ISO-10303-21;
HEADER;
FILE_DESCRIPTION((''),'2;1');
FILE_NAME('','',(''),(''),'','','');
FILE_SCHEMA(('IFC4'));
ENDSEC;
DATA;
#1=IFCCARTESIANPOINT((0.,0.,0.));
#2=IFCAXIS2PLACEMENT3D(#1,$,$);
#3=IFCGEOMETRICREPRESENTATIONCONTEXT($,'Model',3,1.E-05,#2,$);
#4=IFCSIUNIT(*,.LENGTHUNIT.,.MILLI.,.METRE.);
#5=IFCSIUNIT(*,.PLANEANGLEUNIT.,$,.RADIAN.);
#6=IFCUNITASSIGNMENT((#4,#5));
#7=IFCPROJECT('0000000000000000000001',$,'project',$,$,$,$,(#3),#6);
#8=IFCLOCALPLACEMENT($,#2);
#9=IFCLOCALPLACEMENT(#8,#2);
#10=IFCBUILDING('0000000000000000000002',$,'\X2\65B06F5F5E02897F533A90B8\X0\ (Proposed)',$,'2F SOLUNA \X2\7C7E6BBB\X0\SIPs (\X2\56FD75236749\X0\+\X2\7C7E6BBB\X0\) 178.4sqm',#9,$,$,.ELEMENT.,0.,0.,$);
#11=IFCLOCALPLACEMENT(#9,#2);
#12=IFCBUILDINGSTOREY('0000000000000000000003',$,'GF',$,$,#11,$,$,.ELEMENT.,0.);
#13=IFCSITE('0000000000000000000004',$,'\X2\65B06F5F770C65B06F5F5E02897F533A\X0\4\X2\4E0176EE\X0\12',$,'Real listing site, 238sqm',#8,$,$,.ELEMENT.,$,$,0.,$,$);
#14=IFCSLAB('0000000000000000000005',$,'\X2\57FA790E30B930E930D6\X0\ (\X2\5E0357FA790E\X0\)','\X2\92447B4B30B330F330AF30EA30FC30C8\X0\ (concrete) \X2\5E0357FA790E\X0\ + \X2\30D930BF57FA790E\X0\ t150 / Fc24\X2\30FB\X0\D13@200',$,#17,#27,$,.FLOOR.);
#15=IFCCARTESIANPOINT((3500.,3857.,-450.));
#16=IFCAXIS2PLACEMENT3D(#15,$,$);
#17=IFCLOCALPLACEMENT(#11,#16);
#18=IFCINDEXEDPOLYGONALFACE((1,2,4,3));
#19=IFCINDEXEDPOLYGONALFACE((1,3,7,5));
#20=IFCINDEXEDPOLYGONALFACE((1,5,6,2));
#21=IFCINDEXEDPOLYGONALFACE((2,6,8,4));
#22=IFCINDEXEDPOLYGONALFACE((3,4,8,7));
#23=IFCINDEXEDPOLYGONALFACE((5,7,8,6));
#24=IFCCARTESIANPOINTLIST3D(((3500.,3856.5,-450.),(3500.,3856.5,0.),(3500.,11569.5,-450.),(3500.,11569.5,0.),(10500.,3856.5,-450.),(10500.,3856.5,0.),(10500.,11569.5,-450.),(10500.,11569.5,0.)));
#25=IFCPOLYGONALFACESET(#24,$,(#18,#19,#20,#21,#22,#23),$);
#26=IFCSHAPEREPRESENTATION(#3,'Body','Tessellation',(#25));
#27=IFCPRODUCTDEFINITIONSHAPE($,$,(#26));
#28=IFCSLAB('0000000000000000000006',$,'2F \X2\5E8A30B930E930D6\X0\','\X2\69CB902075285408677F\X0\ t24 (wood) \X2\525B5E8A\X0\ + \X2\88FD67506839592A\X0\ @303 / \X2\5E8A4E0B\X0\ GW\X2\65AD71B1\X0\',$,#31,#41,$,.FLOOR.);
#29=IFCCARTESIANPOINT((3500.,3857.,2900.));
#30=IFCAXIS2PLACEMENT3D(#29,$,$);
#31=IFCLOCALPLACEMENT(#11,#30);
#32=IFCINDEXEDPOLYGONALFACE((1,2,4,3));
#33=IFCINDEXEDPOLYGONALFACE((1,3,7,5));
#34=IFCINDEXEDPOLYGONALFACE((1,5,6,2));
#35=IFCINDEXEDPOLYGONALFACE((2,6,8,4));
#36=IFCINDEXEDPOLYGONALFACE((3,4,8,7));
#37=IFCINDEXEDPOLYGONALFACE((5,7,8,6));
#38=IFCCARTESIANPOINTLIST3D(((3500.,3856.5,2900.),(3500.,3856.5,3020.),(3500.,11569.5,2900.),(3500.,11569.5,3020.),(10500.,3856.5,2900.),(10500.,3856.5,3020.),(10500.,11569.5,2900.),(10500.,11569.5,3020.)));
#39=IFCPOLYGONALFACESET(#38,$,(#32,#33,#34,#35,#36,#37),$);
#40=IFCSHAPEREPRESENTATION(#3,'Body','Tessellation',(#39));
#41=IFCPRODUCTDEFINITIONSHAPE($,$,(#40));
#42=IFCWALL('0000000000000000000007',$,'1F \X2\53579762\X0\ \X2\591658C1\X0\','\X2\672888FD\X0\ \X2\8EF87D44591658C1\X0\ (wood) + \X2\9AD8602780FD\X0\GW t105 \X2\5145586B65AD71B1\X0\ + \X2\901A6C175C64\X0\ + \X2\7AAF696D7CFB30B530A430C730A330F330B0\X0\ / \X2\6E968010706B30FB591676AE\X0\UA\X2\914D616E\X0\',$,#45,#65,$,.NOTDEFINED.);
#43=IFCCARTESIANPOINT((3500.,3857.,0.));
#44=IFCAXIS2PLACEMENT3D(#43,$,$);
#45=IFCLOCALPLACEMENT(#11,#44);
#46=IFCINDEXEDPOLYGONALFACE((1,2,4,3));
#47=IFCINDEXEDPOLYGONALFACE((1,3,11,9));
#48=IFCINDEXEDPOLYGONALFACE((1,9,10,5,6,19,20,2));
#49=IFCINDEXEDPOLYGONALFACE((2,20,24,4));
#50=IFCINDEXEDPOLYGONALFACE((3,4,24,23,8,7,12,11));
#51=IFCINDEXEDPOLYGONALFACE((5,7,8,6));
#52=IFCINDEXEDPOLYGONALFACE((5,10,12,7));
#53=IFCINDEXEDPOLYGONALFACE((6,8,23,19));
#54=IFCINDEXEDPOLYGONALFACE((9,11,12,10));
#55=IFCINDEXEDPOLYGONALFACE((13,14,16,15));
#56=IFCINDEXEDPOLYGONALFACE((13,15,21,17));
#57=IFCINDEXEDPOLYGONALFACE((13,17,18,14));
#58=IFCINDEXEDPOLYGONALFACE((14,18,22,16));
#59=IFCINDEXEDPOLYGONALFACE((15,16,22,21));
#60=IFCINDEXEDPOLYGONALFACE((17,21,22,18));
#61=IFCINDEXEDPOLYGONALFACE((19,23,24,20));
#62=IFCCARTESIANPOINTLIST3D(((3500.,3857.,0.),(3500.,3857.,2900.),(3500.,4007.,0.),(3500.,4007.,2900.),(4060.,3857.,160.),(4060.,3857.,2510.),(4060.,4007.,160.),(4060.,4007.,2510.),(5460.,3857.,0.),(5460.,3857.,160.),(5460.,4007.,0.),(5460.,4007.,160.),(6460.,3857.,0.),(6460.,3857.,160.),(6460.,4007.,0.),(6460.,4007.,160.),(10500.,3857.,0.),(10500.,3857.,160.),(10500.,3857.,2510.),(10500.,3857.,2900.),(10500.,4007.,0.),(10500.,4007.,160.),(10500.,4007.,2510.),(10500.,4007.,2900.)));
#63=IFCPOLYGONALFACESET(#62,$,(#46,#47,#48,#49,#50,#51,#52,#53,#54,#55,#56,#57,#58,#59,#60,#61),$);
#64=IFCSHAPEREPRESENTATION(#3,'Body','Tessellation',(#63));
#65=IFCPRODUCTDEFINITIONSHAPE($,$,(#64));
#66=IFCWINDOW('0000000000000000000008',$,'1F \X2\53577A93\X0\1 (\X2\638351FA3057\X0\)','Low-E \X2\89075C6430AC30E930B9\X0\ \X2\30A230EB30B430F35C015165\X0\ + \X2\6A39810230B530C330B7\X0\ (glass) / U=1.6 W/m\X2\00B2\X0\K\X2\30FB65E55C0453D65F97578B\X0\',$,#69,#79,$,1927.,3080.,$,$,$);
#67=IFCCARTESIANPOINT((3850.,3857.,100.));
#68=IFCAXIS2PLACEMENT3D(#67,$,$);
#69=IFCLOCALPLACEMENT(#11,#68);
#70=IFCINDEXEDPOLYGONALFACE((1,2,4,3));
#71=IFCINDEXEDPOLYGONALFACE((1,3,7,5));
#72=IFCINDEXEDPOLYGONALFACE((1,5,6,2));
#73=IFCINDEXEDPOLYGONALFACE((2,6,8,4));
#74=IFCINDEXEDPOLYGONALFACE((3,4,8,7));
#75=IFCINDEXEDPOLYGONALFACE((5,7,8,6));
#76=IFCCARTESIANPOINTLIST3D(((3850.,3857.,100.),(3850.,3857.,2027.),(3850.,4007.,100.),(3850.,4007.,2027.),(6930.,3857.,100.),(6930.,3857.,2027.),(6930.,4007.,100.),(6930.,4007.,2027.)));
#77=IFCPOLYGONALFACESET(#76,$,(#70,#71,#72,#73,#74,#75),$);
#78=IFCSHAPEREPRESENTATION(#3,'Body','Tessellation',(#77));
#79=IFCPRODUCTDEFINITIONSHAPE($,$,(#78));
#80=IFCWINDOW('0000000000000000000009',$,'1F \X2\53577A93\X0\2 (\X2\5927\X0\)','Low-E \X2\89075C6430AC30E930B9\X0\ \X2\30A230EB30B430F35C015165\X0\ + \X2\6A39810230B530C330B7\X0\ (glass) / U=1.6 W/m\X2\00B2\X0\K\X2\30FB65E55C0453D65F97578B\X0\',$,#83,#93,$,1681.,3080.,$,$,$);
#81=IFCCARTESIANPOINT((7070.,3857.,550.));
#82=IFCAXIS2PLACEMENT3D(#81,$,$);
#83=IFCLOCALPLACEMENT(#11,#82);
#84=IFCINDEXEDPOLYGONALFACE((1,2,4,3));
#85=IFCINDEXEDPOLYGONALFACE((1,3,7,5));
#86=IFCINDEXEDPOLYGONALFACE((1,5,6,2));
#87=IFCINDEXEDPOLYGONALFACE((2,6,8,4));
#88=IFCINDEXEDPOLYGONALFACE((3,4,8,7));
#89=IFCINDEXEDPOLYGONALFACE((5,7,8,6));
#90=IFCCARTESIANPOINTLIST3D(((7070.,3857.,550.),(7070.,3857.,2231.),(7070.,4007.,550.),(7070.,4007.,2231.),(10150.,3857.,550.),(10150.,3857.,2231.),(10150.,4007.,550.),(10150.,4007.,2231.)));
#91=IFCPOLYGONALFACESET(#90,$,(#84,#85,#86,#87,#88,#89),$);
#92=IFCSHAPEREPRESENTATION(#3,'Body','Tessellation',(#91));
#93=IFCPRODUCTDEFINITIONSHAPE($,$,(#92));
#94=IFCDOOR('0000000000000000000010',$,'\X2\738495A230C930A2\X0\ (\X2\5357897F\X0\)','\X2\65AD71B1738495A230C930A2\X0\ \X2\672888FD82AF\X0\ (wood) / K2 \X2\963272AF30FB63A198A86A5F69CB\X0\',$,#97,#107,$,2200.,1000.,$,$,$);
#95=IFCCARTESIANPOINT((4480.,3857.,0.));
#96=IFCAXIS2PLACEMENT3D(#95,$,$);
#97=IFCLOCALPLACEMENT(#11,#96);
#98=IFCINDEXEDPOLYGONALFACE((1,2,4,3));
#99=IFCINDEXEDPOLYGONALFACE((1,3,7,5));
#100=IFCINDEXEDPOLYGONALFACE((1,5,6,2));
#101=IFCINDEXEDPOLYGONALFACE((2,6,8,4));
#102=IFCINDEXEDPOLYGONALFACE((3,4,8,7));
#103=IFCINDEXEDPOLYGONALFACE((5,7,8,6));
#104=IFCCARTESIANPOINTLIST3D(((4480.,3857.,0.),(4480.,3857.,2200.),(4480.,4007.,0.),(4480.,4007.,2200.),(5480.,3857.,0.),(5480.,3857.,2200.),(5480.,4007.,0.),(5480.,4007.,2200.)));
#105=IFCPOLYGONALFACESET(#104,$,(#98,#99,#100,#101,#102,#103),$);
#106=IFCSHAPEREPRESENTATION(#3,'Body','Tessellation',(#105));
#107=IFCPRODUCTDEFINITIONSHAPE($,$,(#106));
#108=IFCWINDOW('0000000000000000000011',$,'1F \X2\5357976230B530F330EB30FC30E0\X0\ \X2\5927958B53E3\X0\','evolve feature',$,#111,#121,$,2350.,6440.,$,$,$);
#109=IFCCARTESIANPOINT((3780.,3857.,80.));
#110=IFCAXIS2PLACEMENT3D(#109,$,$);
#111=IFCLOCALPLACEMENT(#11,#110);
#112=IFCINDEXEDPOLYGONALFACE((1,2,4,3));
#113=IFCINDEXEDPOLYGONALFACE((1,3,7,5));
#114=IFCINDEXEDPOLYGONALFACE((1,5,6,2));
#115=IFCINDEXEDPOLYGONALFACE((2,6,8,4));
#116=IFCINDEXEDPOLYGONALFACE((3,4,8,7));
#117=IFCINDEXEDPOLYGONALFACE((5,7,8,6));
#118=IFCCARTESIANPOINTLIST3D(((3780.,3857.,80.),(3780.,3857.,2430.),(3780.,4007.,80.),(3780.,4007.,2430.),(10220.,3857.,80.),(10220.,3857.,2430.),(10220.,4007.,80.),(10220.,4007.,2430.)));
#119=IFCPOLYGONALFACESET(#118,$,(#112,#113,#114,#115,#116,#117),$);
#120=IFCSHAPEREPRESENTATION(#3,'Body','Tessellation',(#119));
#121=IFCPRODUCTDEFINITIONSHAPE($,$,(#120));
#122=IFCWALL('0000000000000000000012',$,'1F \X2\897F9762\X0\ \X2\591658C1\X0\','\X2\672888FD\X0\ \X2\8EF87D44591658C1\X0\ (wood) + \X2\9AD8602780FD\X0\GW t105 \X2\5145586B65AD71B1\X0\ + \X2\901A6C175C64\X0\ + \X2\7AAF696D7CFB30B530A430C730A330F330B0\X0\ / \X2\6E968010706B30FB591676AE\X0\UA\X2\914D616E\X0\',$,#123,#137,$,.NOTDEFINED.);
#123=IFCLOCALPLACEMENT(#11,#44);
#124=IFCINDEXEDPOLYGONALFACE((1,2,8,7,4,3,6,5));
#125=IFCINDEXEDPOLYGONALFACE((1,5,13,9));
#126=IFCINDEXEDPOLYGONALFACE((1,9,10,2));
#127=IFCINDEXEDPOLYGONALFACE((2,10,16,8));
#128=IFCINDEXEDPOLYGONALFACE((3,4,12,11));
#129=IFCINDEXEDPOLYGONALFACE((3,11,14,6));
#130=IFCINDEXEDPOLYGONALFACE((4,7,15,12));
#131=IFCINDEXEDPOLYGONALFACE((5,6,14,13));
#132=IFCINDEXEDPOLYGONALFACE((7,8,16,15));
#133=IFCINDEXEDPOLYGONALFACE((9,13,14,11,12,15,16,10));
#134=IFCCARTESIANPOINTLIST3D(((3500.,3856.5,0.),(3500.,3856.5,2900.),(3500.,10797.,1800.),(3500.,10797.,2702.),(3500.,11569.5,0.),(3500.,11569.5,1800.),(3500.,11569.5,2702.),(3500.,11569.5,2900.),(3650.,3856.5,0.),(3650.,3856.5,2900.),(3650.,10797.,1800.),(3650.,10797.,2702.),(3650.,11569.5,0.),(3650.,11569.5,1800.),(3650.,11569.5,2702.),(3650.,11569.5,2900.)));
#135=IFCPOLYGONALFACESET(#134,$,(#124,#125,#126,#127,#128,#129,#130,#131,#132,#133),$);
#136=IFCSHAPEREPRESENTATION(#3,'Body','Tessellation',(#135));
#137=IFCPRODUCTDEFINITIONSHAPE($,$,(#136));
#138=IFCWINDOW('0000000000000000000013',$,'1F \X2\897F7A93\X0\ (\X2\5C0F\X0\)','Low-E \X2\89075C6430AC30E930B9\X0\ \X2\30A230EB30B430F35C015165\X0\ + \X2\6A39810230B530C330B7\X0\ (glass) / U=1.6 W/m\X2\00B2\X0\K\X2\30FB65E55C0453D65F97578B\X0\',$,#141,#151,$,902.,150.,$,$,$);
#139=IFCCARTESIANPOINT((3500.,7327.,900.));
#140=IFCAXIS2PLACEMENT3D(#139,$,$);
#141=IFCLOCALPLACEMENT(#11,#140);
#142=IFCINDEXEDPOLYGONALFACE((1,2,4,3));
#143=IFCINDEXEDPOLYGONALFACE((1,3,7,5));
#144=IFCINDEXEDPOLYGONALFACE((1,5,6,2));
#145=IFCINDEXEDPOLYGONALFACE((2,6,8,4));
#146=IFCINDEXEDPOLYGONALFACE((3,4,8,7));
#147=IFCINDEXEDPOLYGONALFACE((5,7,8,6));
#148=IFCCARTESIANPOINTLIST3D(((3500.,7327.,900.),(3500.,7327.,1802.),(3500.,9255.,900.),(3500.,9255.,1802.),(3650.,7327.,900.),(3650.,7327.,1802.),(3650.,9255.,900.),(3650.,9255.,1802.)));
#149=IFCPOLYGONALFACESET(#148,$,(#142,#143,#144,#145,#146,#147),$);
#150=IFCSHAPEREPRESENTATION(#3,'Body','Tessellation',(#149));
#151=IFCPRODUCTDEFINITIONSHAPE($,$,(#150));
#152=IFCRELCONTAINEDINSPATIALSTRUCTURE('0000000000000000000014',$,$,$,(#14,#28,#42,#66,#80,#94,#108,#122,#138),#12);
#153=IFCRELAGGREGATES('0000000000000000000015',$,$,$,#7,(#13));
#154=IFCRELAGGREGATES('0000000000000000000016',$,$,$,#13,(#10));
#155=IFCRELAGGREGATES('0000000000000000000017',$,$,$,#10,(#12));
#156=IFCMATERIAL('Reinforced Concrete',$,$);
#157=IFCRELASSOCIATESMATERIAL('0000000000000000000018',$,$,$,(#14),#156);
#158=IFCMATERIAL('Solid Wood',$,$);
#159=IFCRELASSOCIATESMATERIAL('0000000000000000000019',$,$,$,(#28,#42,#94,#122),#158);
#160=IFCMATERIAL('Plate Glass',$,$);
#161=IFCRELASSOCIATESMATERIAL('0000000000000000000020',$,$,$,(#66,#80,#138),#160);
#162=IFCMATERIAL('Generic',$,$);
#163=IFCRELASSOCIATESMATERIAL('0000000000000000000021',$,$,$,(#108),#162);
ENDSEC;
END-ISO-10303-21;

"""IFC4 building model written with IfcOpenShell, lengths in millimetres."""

from ifc_helpers import new_model, si_unit, frame, frame_2d, origin, place, context, project, spatial, rectangle, extrude, material, element, fill, save


model = new_model("IFC4")

# Units and contexts
model_context = context("Model", 3, precision=1e-05, world=origin())
ifc_project = project(units=[si_unit("LENGTHUNIT", "METRE", prefix="MILLI"), si_unit("PLANEANGLEUNIT", "RADIAN")], contexts=[model_context])

# Site, building, storey
site_placement = place(None, origin())
site = spatial("IfcSite", under=ifc_project, at=site_placement, Name="新潟県新潟市西区4丁目12", ObjectType="Real listing site, 238sqm", CompositionType="ELEMENT", RefElevation=0.0)
building_placement = place(site_placement, origin())
building = spatial("IfcBuilding", under=site, at=building_placement, Name="新潟市西区邸 (Proposed)", ObjectType="2F SOLUNA 籾殻SIPs (国産杉+籾殻) 178.4sqm", CompositionType="ELEMENT", ElevationOfRefHeight=0.0, ElevationOfTerrain=0.0)
storey_placement = place(building_placement, origin())
storey = spatial("IfcBuildingStorey", under=building, at=storey_placement, Name="GF", CompositionType="ELEMENT", Elevation=0.0)

# Slabs
ifc_material_1 = material(Name="Reinforced Concrete")
slab_1_placement = place(storey_placement, frame((3500.0, 3857.0, -450.0)))
element("IfcSlab", 1, at=slab_1_placement, inside=storey, material=ifc_material_1, Name="基礎スラブ (布基礎)", Description="鉄筋コンクリート (concrete) 布基礎 + ベタ基礎 t150 / Fc24・D13@200", PredefinedType="FLOOR", context=model_context, shape_type="SweptSolid", body=[
    extrude(rectangle(XDim=7000.0, YDim=7713.0, at=frame_2d((3500.0, 3856.0))), frame((3500.0, 3857.0, -450.0)), (0.0, 0.0, 1.0), 450.0),
])
ifc_material_2 = material(Name="Solid Wood")
slab_2_placement = place(storey_placement, frame((3500.0, 3857.0, 2900.0)))
element("IfcSlab", 2, at=slab_2_placement, inside=storey, material=ifc_material_2, Name="2F 床スラブ", Description="構造用合板 t24 (wood) 剛床 + 製材根太 @303 / 床下 GW断熱", PredefinedType="FLOOR", context=model_context, shape_type="SweptSolid", body=[
    extrude(rectangle(XDim=7000.0, YDim=7713.0, at=frame_2d((3500.0, 3856.0))), frame((3500.0, 3857.0, 2900.0)), (0.0, 0.0, 1.0), 120.0),
])
ifc_material_3 = material(Name="Generic")

# Wall, openings, windows, door
wall_1_placement = place(storey_placement, frame((3500.0, 3857.0, 0.0)))
wall_1 = element("IfcWall", 3, at=wall_1_placement, inside=storey, material=ifc_material_2, Name="1F 南面 外壁", Description="木製 軸組外壁 (wood) + 高性能GW t105 充填断熱 + 通気層 + 窯業系サイディング / 準耐火・外皮UA配慮", PredefinedType="NOTDEFINED", context=model_context, shape_type="SweptSolid", body=[
    extrude(rectangle(XDim=7000.0, YDim=150.0, at=frame_2d((3500.0, 75.0))), frame((3500.0, 3857.0, 0.0)), (0.0, 0.0, 1.0), 2900.0),
])
opening_1_placement = place(storey_placement, frame((3850.0, 3857.0, 100.0)))
opening_1 = element("IfcOpeningElement", 4, at=opening_1_placement, cuts=wall_1, PredefinedType="NOTDEFINED", context=model_context, shape_type="SweptSolid", body=[
    extrude(rectangle(XDim=3080.0, YDim=150.0, at=frame_2d((1540.0, 75.0))), frame((3850.0, 3857.0, 100.0)), (0.0, 0.0, 1.0), 1927.0),
])
opening_2_placement = place(storey_placement, frame((7070.0, 3857.0, 550.0)))
opening_2 = element("IfcOpeningElement", 5, at=opening_2_placement, cuts=wall_1, PredefinedType="NOTDEFINED", context=model_context, shape_type="SweptSolid", body=[
    extrude(rectangle(XDim=3080.0, YDim=150.0, at=frame_2d((1540.0, 75.0))), frame((7070.0, 3857.0, 550.0)), (0.0, 0.0, 1.0), 1681.0),
])
opening_3_placement = place(storey_placement, frame((4480.0, 3857.0, 0.0)))
opening_3 = element("IfcOpeningElement", 6, at=opening_3_placement, cuts=wall_1, PredefinedType="NOTDEFINED", context=model_context, shape_type="SweptSolid", body=[
    extrude(rectangle(XDim=1000.0, YDim=150.0, at=frame_2d((500.0, 75.0))), frame((4480.0, 3857.0, 0.0)), (0.0, 0.0, 1.0), 2200.0),
])
opening_4_placement = place(storey_placement, frame((3780.0, 3857.0, 80.0)))
opening_4 = element("IfcOpeningElement", 7, at=opening_4_placement, cuts=wall_1, PredefinedType="NOTDEFINED", context=model_context, shape_type="SweptSolid", body=[
    extrude(rectangle(XDim=6440.0, YDim=150.0, at=frame_2d((3220.0, 75.0))), frame((3780.0, 3857.0, 80.0)), (0.0, 0.0, 1.0), 2350.0),
])
ifc_material_4 = material(Name="Plate Glass")
window_1_placement = place(storey_placement, frame((3850.0, 3857.0, 100.0)))
window_1 = element("IfcWindow", 8, at=window_1_placement, inside=storey, material=ifc_material_4, Name="1F 南窓1 (掃出し)", Description="Low-E 複層ガラス アルゴン封入 + 樹脂サッシ (glass) / U=1.6 W/m²K・日射取得型", OverallHeight=1927.0, OverallWidth=3080.0, context=model_context, shape_type="SweptSolid", body=[
    extrude(rectangle(XDim=3080.0, YDim=150.0, at=frame_2d((1540.0, 75.0))), frame((3850.0, 3857.0, 100.0)), (0.0, 0.0, 1.0), 1927.0),
])
fill(opening_1, window_1)
window_2_placement = place(storey_placement, frame((7070.0, 3857.0, 550.0)))
window_2 = element("IfcWindow", 9, at=window_2_placement, inside=storey, material=ifc_material_4, Name="1F 南窓2 (大)", Description="Low-E 複層ガラス アルゴン封入 + 樹脂サッシ (glass) / U=1.6 W/m²K・日射取得型", OverallHeight=1681.0, OverallWidth=3080.0, context=model_context, shape_type="SweptSolid", body=[
    extrude(rectangle(XDim=3080.0, YDim=150.0, at=frame_2d((1540.0, 75.0))), frame((7070.0, 3857.0, 550.0)), (0.0, 0.0, 1.0), 1681.0),
])
fill(opening_2, window_2)
door_placement = place(storey_placement, frame((4480.0, 3857.0, 0.0)))
door = element("IfcDoor", 10, at=door_placement, inside=storey, material=ifc_material_2, Name="玄関ドア (南西)", Description="断熱玄関ドア 木製芯 (wood) / K2 防犯・採風機構", OverallHeight=2200.0, OverallWidth=1000.0, context=model_context, shape_type="SweptSolid", body=[
    extrude(rectangle(XDim=1000.0, YDim=150.0, at=frame_2d((500.0, 75.0))), frame((4480.0, 3857.0, 0.0)), (0.0, 0.0, 1.0), 2200.0),
])
fill(opening_3, door)
window_3_placement = place(storey_placement, frame((3780.0, 3857.0, 80.0)))
window_3 = element("IfcWindow", 11, at=window_3_placement, inside=storey, material=ifc_material_3, Name="1F 南面サンルーム 大開口", Description="evolve feature", OverallHeight=2350.0, OverallWidth=6440.0, context=model_context, shape_type="SweptSolid", body=[
    extrude(rectangle(XDim=6440.0, YDim=150.0, at=frame_2d((3220.0, 75.0))), frame((3780.0, 3857.0, 80.0)), (0.0, 0.0, 1.0), 2350.0),
])
fill(opening_4, window_3)

# Wall, opening, window
wall_2_placement = place(storey_placement, frame((3500.0, 3857.0, 0.0)))
wall_2 = element("IfcWall", 12, at=wall_2_placement, inside=storey, material=ifc_material_2, Name="1F 西面 外壁", Description="木製 軸組外壁 (wood) + 高性能GW t105 充填断熱 + 通気層 + 窯業系サイディング / 準耐火・外皮UA配慮", PredefinedType="NOTDEFINED", context=model_context, shape_type="SweptSolid", body=[
    extrude(rectangle(XDim=150.0, YDim=7713.0, at=frame_2d((75.0, 3856.0))), frame((3500.0, 3857.0, 0.0)), (0.0, 0.0, 1.0), 2900.0),
])
opening_5_placement = place(storey_placement, frame((3500.0, 7327.0, 900.0)))
opening_5 = element("IfcOpeningElement", 13, at=opening_5_placement, cuts=wall_2, PredefinedType="NOTDEFINED", context=model_context, shape_type="SweptSolid", body=[
    extrude(rectangle(XDim=150.0, YDim=1928.0, at=frame_2d((75.0, 964.0))), frame((3500.0, 7327.0, 900.0)), (0.0, 0.0, 1.0), 902.0),
])
window_4_placement = place(storey_placement, frame((3500.0, 7327.0, 900.0)))
window_4 = element("IfcWindow", 14, at=window_4_placement, inside=storey, material=ifc_material_4, Name="1F 西窓 (小)", Description="Low-E 複層ガラス アルゴン封入 + 樹脂サッシ (glass) / U=1.6 W/m²K・日射取得型", OverallHeight=902.0, OverallWidth=150.0, context=model_context, shape_type="SweptSolid", body=[
    extrude(rectangle(XDim=150.0, YDim=1928.0, at=frame_2d((75.0, 964.0))), frame((3500.0, 7327.0, 900.0)), (0.0, 0.0, 1.0), 902.0),
])
fill(opening_5, window_4)

save(model, "model.ifc")
